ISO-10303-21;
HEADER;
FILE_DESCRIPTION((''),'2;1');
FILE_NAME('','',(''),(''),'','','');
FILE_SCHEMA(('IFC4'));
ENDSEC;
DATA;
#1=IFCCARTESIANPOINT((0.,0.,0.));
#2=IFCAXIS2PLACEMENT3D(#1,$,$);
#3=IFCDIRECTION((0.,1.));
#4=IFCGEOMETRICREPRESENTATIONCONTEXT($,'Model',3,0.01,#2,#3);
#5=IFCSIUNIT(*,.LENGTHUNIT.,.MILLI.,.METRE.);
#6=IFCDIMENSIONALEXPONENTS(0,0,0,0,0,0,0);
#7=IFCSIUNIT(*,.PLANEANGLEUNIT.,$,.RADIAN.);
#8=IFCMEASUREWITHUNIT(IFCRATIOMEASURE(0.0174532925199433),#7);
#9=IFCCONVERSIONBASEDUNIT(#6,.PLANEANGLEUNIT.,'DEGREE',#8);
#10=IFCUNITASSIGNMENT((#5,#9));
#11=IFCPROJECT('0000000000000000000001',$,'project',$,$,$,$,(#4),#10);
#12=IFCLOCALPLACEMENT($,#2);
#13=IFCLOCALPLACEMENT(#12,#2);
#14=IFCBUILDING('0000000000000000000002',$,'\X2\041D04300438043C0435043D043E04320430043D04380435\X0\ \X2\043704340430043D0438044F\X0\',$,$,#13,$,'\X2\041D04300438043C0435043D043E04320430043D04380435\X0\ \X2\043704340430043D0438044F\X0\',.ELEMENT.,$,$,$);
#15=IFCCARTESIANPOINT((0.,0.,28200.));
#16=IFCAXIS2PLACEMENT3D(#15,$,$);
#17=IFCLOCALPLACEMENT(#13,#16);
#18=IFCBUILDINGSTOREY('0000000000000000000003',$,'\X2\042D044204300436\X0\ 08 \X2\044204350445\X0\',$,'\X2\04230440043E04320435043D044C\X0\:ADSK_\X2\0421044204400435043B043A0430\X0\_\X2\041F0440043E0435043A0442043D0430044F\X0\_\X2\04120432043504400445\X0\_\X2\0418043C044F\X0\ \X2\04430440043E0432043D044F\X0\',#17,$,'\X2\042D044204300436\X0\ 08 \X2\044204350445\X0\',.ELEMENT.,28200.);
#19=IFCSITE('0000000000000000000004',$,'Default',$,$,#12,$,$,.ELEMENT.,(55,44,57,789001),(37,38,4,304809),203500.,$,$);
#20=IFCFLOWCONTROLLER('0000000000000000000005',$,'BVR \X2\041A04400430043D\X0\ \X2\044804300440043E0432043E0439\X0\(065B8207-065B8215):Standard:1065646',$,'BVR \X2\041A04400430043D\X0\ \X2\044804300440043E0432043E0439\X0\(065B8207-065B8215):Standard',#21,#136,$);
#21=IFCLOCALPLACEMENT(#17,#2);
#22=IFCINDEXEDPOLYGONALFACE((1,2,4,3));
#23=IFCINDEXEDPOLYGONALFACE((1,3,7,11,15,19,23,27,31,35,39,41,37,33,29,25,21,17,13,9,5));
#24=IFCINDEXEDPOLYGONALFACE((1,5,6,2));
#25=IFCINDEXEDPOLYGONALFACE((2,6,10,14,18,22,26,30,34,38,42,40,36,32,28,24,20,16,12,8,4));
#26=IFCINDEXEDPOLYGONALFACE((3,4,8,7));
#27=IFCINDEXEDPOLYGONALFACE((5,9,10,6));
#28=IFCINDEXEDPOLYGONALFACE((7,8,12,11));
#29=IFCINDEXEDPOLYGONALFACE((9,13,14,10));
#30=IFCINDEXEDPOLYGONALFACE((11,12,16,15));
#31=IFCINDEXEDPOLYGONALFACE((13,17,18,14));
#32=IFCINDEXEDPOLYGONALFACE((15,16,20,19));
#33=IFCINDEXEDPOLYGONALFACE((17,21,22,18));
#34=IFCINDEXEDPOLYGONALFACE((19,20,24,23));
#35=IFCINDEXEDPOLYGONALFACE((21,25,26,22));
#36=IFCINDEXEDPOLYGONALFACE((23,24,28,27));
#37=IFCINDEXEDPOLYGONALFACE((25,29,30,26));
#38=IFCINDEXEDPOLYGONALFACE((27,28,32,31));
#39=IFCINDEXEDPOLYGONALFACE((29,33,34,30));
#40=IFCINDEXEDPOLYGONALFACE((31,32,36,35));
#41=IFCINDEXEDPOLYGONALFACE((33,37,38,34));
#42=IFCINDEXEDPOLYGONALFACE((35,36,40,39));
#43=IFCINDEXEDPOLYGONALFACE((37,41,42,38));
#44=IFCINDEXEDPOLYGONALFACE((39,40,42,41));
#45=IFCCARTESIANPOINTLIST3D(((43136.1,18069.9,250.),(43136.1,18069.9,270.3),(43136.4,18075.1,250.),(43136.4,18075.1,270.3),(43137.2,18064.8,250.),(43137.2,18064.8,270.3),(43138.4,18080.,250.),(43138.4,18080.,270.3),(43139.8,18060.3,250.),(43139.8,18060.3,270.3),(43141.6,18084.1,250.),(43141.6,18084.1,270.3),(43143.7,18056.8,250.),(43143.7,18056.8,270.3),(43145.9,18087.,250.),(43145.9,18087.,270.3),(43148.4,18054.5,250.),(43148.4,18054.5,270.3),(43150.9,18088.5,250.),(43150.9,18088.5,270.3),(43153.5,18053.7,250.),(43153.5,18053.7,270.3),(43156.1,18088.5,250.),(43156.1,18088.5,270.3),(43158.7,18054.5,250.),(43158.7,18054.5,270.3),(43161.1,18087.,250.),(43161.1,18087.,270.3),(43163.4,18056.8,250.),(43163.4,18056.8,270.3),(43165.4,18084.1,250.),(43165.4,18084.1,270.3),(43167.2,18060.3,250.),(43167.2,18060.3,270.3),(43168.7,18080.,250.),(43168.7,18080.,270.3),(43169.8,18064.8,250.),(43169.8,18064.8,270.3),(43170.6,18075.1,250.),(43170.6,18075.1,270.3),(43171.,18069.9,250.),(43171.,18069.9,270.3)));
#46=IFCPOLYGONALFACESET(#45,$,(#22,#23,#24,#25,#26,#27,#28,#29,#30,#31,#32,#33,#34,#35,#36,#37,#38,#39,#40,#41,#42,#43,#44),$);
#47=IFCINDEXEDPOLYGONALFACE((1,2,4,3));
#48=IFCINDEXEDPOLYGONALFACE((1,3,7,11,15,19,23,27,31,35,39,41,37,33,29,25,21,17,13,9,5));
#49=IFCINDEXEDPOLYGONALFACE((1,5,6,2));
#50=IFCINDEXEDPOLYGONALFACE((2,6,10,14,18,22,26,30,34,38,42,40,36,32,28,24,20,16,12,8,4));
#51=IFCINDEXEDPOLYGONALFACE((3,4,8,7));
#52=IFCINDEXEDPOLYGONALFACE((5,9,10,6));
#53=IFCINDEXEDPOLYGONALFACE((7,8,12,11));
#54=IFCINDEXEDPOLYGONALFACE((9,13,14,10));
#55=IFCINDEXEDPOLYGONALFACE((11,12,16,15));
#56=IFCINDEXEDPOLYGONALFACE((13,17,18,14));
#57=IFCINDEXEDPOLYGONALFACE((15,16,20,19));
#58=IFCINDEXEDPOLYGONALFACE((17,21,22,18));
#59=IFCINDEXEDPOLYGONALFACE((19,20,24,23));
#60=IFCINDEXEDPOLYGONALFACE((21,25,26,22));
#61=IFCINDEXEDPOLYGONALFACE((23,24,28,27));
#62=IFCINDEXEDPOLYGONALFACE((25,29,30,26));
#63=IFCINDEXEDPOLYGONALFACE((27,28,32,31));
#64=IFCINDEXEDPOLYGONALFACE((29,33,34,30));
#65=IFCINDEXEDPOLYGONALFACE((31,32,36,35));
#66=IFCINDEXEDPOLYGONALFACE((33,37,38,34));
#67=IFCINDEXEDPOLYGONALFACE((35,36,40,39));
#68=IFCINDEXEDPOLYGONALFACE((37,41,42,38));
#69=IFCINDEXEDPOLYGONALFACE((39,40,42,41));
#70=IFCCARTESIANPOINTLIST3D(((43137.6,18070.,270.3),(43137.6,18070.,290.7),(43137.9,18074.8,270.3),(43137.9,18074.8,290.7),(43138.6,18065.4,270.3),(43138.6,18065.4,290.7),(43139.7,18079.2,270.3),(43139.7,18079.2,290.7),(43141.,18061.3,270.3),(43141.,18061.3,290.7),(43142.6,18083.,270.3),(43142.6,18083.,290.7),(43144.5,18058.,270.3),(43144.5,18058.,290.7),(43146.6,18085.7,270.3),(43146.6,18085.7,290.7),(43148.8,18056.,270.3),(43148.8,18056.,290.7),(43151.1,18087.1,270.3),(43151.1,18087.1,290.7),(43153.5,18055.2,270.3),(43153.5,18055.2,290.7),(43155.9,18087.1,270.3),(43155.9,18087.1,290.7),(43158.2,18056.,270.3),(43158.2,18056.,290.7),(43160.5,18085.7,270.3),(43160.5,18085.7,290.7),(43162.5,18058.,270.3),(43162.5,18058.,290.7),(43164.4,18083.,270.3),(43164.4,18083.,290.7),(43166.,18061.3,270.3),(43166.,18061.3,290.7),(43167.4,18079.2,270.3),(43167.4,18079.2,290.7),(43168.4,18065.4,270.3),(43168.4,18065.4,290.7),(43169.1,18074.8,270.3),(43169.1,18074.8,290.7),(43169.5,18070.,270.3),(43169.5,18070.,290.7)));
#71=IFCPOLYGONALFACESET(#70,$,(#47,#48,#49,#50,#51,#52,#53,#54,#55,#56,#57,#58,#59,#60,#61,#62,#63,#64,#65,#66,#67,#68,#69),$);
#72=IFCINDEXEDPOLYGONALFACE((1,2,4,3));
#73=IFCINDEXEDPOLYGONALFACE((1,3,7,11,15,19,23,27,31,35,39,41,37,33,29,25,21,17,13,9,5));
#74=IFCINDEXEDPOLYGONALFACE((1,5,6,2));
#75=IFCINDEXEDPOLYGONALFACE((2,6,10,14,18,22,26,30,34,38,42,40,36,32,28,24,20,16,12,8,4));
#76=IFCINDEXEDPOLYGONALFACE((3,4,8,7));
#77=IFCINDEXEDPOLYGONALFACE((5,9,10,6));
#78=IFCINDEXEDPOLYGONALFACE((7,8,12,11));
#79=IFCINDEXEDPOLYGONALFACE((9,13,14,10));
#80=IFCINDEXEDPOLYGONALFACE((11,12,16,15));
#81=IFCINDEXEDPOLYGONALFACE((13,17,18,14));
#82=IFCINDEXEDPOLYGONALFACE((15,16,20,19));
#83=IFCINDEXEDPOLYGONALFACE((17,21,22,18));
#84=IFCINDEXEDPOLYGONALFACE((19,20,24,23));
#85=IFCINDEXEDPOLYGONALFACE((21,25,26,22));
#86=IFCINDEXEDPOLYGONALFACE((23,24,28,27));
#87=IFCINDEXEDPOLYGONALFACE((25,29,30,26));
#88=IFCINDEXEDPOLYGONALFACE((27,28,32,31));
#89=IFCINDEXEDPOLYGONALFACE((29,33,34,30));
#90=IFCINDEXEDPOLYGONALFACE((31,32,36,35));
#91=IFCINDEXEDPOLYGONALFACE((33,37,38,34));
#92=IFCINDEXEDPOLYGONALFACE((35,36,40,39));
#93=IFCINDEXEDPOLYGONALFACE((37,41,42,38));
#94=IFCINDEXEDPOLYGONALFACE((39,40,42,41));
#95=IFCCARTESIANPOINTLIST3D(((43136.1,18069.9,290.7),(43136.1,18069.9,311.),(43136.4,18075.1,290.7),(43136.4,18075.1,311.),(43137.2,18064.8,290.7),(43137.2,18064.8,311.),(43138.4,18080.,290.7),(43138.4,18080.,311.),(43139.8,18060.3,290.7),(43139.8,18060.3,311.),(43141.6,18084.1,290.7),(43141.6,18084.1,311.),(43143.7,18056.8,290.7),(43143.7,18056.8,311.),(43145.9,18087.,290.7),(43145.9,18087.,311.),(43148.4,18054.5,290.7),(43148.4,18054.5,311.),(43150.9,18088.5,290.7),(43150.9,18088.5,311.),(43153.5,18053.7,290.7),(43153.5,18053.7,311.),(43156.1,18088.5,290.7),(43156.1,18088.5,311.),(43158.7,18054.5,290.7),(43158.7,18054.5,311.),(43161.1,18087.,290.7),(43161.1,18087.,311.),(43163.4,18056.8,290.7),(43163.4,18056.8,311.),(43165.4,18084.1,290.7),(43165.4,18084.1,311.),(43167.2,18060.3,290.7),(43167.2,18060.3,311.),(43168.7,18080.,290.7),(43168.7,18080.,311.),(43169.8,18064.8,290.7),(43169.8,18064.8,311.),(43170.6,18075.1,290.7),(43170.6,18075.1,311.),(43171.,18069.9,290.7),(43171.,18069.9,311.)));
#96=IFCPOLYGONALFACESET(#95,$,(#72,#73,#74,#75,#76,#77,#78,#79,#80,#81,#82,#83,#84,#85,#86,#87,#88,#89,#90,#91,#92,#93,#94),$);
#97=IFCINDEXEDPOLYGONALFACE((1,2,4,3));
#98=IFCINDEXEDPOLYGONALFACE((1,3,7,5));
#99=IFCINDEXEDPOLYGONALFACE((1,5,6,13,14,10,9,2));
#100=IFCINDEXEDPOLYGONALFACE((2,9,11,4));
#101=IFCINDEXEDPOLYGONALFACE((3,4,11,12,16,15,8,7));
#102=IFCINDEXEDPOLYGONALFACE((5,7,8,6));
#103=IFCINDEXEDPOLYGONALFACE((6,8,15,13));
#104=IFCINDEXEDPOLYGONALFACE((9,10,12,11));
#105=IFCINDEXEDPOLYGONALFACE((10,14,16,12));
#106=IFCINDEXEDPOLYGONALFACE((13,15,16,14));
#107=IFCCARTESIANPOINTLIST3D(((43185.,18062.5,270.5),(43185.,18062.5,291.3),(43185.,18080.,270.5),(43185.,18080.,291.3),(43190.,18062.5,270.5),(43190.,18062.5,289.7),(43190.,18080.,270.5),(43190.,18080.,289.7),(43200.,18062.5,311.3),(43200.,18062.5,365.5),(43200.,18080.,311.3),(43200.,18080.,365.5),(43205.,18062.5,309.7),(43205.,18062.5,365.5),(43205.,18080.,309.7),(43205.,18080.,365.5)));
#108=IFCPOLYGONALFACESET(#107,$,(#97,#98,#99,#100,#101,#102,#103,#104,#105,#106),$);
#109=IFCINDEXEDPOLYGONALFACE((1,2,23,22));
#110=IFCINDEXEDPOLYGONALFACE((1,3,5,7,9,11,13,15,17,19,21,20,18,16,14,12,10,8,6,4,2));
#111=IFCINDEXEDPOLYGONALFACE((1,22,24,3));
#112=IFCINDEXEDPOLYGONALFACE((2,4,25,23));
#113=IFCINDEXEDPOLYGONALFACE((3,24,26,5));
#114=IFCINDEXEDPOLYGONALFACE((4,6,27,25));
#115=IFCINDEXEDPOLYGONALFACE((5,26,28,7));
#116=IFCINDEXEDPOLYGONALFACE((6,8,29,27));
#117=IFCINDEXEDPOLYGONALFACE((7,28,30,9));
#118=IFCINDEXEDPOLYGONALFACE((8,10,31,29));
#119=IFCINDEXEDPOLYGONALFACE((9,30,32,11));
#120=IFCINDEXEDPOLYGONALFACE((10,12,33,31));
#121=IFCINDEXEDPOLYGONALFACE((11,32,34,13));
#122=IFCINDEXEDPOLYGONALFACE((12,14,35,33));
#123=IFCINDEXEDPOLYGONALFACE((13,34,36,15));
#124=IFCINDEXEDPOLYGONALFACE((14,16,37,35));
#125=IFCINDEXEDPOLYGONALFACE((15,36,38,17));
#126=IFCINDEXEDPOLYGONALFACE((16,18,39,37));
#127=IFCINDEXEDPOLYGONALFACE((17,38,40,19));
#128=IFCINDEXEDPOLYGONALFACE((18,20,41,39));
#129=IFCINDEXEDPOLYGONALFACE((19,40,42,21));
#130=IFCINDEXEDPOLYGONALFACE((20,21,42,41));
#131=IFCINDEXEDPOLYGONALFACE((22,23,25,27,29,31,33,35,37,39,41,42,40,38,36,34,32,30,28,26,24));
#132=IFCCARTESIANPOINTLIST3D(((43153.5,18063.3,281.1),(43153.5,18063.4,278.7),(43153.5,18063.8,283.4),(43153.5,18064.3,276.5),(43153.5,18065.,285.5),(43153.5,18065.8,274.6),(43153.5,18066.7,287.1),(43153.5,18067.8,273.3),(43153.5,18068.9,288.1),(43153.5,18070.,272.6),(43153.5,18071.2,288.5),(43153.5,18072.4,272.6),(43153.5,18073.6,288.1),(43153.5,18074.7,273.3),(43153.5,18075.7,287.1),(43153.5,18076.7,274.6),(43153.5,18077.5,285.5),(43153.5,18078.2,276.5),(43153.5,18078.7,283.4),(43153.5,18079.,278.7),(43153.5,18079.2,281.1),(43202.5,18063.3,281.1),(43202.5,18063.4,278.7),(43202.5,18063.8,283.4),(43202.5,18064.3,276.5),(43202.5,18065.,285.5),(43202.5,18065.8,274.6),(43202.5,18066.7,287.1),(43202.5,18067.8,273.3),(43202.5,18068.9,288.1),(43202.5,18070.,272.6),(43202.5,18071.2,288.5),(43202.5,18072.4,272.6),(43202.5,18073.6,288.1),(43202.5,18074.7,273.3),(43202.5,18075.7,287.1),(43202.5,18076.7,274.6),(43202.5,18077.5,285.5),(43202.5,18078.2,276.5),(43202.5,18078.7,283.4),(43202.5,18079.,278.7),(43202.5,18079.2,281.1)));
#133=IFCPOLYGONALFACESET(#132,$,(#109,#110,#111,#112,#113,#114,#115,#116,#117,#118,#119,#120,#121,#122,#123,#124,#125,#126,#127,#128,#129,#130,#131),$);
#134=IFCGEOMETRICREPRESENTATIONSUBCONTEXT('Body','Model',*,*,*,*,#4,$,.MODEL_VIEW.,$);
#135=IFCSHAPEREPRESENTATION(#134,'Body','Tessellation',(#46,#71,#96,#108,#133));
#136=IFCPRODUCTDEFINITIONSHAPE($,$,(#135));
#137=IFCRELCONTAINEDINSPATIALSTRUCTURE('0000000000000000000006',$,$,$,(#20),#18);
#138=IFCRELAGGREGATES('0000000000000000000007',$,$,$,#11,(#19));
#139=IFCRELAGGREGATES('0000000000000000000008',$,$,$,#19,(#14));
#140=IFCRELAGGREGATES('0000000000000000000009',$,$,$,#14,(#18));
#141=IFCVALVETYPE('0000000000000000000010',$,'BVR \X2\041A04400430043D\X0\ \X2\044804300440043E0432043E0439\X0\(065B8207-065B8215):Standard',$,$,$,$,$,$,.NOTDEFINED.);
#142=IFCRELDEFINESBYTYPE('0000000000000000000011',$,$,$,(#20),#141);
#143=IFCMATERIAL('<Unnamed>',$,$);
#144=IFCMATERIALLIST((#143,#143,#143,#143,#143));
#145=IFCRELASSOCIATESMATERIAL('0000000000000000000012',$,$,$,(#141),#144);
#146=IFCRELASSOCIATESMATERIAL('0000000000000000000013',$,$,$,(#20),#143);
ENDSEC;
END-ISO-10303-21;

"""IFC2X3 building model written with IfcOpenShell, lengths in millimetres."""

from ifc_helpers import new_model, entity, si_unit, converted_unit, direction, frame, origin, origin_2d_with_axis, place, context, subcontext, project, spatial, polyline, circle, outline, extrude, source, transform, mapped, material, material_list, type_object, type_shapes, element, save


model = new_model("IFC2X3")

# Units and contexts
model_context = context("Model", 3, precision=0.01, world=origin(), true_north=direction((0.0, 1.0)))
body_context = subcontext(model_context, "Body", "Model", "MODEL_VIEW")
ifc_project = project(units=[si_unit("LENGTHUNIT", "METRE", prefix="MILLI"), converted_unit("PLANEANGLEUNIT", "DEGREE", entity("IfcRatioMeasure", 0.0174532925199433), si_unit("PLANEANGLEUNIT", "RADIAN"), dimensions=[0, 0, 0, 0, 0, 0, 0])], contexts=[model_context])

# Site, building, storey
site_placement = place(None, origin())
site = spatial("IfcSite", under=ifc_project, at=site_placement, Name="Default", CompositionType="ELEMENT", RefLatitude=(55, 44, 57, 789001), RefLongitude=(37, 38, 4, 304809), RefElevation=203500.0)
building_placement = place(site_placement, origin())
building = spatial("IfcBuilding", under=site, at=building_placement, Name="Наименование здания", LongName="Наименование здания", CompositionType="ELEMENT")
storey_placement = place(building_placement, frame((0.0, 0.0, 28200.0)))
storey = spatial("IfcBuildingStorey", under=building, at=storey_placement, Name="Этаж 08 тех", ObjectType="Уровень:ADSK_Стрелка_Проектная_Вверх_Имя уровня", LongName="Этаж 08 тех", CompositionType="ELEMENT", Elevation=28200.0)

# Shared definitions
ifc_material = material(Name="<Unnamed>")

# Flow controller
ifc_material_list = material_list([ifc_material, ifc_material, ifc_material, ifc_material, ifc_material])
valve_type = type_object("IfcValveType", Name="BVR Кран шаровой(065B8207-065B8215):Standard", PredefinedType="NOTDEFINED", material=ifc_material_list)
shared_shape_1 = source(origin(), body_context, "Body", "SweptSolid", [
    extrude(circle(Radius=17.5, at=origin_2d_with_axis()), frame((-30.5, 0.0, 0.0), z_axis=(1.0, 0.0, 0.0), x_axis=(0.0, 1.0, 0.0)), (0.0, 0.0, 1.0), 20.3),
    extrude(circle(Radius=16.0, at=origin_2d_with_axis()), frame((-10.2, 0.0, 0.0), z_axis=(1.0, 0.0, 0.0), x_axis=(0.0, 1.0, 0.0)), (0.0, 0.0, 1.0), 20.3),
    extrude(circle(Radius=17.5, at=origin_2d_with_axis()), frame((10.2, 0.0, 0.0), z_axis=(1.0, 0.0, 0.0), x_axis=(0.0, 1.0, 0.0)), (0.0, 0.0, 1.0), 20.3),
    extrude(outline(polyline([(-38.8, -5.0), (-38.8, -10.0), (-17.9, -10.0), (2.1, 5.0), (56.2, 5.0), (56.2, 10.0), (0.4, 10.0), (-19.6, -5.0), (-38.8, -5.0)])), frame((28.8, -8.8, 41.5), z_axis=(0.0, -1.0, 0.0), x_axis=(1.0, 0.0, 0.0)), (0.0, 0.0, -1.0), 17.5),
    extrude(circle(Radius=8.0, at=origin_2d_with_axis()), origin(), (0.0, 0.0, 1.0), 49.0),
])
type_shapes(valve_type, [shared_shape_1])
for number, where, z_axis, x_axis, name in (
    (1, (43153.5, 18071.2, 280.5), (1.0, 0.0, 0.0), (0.0, 0.0, 1.0), "BVR Кран шаровой(065B8207-065B8215):Standard:1065646"),
):
    element("IfcFlowController", number, at=place(storey_placement, frame(where, z_axis=z_axis, x_axis=x_axis)), inside=storey, type_object=valve_type, material=ifc_material, Name=name, ObjectType="BVR Кран шаровой(065B8207-065B8215):Standard", context=body_context, shape_type="MappedRepresentation", body=[
        mapped(shared_shape_1, transform((0.0, 0.0, 0.0), scale=1.0)),
    ])

save(model, "model.ifc")
